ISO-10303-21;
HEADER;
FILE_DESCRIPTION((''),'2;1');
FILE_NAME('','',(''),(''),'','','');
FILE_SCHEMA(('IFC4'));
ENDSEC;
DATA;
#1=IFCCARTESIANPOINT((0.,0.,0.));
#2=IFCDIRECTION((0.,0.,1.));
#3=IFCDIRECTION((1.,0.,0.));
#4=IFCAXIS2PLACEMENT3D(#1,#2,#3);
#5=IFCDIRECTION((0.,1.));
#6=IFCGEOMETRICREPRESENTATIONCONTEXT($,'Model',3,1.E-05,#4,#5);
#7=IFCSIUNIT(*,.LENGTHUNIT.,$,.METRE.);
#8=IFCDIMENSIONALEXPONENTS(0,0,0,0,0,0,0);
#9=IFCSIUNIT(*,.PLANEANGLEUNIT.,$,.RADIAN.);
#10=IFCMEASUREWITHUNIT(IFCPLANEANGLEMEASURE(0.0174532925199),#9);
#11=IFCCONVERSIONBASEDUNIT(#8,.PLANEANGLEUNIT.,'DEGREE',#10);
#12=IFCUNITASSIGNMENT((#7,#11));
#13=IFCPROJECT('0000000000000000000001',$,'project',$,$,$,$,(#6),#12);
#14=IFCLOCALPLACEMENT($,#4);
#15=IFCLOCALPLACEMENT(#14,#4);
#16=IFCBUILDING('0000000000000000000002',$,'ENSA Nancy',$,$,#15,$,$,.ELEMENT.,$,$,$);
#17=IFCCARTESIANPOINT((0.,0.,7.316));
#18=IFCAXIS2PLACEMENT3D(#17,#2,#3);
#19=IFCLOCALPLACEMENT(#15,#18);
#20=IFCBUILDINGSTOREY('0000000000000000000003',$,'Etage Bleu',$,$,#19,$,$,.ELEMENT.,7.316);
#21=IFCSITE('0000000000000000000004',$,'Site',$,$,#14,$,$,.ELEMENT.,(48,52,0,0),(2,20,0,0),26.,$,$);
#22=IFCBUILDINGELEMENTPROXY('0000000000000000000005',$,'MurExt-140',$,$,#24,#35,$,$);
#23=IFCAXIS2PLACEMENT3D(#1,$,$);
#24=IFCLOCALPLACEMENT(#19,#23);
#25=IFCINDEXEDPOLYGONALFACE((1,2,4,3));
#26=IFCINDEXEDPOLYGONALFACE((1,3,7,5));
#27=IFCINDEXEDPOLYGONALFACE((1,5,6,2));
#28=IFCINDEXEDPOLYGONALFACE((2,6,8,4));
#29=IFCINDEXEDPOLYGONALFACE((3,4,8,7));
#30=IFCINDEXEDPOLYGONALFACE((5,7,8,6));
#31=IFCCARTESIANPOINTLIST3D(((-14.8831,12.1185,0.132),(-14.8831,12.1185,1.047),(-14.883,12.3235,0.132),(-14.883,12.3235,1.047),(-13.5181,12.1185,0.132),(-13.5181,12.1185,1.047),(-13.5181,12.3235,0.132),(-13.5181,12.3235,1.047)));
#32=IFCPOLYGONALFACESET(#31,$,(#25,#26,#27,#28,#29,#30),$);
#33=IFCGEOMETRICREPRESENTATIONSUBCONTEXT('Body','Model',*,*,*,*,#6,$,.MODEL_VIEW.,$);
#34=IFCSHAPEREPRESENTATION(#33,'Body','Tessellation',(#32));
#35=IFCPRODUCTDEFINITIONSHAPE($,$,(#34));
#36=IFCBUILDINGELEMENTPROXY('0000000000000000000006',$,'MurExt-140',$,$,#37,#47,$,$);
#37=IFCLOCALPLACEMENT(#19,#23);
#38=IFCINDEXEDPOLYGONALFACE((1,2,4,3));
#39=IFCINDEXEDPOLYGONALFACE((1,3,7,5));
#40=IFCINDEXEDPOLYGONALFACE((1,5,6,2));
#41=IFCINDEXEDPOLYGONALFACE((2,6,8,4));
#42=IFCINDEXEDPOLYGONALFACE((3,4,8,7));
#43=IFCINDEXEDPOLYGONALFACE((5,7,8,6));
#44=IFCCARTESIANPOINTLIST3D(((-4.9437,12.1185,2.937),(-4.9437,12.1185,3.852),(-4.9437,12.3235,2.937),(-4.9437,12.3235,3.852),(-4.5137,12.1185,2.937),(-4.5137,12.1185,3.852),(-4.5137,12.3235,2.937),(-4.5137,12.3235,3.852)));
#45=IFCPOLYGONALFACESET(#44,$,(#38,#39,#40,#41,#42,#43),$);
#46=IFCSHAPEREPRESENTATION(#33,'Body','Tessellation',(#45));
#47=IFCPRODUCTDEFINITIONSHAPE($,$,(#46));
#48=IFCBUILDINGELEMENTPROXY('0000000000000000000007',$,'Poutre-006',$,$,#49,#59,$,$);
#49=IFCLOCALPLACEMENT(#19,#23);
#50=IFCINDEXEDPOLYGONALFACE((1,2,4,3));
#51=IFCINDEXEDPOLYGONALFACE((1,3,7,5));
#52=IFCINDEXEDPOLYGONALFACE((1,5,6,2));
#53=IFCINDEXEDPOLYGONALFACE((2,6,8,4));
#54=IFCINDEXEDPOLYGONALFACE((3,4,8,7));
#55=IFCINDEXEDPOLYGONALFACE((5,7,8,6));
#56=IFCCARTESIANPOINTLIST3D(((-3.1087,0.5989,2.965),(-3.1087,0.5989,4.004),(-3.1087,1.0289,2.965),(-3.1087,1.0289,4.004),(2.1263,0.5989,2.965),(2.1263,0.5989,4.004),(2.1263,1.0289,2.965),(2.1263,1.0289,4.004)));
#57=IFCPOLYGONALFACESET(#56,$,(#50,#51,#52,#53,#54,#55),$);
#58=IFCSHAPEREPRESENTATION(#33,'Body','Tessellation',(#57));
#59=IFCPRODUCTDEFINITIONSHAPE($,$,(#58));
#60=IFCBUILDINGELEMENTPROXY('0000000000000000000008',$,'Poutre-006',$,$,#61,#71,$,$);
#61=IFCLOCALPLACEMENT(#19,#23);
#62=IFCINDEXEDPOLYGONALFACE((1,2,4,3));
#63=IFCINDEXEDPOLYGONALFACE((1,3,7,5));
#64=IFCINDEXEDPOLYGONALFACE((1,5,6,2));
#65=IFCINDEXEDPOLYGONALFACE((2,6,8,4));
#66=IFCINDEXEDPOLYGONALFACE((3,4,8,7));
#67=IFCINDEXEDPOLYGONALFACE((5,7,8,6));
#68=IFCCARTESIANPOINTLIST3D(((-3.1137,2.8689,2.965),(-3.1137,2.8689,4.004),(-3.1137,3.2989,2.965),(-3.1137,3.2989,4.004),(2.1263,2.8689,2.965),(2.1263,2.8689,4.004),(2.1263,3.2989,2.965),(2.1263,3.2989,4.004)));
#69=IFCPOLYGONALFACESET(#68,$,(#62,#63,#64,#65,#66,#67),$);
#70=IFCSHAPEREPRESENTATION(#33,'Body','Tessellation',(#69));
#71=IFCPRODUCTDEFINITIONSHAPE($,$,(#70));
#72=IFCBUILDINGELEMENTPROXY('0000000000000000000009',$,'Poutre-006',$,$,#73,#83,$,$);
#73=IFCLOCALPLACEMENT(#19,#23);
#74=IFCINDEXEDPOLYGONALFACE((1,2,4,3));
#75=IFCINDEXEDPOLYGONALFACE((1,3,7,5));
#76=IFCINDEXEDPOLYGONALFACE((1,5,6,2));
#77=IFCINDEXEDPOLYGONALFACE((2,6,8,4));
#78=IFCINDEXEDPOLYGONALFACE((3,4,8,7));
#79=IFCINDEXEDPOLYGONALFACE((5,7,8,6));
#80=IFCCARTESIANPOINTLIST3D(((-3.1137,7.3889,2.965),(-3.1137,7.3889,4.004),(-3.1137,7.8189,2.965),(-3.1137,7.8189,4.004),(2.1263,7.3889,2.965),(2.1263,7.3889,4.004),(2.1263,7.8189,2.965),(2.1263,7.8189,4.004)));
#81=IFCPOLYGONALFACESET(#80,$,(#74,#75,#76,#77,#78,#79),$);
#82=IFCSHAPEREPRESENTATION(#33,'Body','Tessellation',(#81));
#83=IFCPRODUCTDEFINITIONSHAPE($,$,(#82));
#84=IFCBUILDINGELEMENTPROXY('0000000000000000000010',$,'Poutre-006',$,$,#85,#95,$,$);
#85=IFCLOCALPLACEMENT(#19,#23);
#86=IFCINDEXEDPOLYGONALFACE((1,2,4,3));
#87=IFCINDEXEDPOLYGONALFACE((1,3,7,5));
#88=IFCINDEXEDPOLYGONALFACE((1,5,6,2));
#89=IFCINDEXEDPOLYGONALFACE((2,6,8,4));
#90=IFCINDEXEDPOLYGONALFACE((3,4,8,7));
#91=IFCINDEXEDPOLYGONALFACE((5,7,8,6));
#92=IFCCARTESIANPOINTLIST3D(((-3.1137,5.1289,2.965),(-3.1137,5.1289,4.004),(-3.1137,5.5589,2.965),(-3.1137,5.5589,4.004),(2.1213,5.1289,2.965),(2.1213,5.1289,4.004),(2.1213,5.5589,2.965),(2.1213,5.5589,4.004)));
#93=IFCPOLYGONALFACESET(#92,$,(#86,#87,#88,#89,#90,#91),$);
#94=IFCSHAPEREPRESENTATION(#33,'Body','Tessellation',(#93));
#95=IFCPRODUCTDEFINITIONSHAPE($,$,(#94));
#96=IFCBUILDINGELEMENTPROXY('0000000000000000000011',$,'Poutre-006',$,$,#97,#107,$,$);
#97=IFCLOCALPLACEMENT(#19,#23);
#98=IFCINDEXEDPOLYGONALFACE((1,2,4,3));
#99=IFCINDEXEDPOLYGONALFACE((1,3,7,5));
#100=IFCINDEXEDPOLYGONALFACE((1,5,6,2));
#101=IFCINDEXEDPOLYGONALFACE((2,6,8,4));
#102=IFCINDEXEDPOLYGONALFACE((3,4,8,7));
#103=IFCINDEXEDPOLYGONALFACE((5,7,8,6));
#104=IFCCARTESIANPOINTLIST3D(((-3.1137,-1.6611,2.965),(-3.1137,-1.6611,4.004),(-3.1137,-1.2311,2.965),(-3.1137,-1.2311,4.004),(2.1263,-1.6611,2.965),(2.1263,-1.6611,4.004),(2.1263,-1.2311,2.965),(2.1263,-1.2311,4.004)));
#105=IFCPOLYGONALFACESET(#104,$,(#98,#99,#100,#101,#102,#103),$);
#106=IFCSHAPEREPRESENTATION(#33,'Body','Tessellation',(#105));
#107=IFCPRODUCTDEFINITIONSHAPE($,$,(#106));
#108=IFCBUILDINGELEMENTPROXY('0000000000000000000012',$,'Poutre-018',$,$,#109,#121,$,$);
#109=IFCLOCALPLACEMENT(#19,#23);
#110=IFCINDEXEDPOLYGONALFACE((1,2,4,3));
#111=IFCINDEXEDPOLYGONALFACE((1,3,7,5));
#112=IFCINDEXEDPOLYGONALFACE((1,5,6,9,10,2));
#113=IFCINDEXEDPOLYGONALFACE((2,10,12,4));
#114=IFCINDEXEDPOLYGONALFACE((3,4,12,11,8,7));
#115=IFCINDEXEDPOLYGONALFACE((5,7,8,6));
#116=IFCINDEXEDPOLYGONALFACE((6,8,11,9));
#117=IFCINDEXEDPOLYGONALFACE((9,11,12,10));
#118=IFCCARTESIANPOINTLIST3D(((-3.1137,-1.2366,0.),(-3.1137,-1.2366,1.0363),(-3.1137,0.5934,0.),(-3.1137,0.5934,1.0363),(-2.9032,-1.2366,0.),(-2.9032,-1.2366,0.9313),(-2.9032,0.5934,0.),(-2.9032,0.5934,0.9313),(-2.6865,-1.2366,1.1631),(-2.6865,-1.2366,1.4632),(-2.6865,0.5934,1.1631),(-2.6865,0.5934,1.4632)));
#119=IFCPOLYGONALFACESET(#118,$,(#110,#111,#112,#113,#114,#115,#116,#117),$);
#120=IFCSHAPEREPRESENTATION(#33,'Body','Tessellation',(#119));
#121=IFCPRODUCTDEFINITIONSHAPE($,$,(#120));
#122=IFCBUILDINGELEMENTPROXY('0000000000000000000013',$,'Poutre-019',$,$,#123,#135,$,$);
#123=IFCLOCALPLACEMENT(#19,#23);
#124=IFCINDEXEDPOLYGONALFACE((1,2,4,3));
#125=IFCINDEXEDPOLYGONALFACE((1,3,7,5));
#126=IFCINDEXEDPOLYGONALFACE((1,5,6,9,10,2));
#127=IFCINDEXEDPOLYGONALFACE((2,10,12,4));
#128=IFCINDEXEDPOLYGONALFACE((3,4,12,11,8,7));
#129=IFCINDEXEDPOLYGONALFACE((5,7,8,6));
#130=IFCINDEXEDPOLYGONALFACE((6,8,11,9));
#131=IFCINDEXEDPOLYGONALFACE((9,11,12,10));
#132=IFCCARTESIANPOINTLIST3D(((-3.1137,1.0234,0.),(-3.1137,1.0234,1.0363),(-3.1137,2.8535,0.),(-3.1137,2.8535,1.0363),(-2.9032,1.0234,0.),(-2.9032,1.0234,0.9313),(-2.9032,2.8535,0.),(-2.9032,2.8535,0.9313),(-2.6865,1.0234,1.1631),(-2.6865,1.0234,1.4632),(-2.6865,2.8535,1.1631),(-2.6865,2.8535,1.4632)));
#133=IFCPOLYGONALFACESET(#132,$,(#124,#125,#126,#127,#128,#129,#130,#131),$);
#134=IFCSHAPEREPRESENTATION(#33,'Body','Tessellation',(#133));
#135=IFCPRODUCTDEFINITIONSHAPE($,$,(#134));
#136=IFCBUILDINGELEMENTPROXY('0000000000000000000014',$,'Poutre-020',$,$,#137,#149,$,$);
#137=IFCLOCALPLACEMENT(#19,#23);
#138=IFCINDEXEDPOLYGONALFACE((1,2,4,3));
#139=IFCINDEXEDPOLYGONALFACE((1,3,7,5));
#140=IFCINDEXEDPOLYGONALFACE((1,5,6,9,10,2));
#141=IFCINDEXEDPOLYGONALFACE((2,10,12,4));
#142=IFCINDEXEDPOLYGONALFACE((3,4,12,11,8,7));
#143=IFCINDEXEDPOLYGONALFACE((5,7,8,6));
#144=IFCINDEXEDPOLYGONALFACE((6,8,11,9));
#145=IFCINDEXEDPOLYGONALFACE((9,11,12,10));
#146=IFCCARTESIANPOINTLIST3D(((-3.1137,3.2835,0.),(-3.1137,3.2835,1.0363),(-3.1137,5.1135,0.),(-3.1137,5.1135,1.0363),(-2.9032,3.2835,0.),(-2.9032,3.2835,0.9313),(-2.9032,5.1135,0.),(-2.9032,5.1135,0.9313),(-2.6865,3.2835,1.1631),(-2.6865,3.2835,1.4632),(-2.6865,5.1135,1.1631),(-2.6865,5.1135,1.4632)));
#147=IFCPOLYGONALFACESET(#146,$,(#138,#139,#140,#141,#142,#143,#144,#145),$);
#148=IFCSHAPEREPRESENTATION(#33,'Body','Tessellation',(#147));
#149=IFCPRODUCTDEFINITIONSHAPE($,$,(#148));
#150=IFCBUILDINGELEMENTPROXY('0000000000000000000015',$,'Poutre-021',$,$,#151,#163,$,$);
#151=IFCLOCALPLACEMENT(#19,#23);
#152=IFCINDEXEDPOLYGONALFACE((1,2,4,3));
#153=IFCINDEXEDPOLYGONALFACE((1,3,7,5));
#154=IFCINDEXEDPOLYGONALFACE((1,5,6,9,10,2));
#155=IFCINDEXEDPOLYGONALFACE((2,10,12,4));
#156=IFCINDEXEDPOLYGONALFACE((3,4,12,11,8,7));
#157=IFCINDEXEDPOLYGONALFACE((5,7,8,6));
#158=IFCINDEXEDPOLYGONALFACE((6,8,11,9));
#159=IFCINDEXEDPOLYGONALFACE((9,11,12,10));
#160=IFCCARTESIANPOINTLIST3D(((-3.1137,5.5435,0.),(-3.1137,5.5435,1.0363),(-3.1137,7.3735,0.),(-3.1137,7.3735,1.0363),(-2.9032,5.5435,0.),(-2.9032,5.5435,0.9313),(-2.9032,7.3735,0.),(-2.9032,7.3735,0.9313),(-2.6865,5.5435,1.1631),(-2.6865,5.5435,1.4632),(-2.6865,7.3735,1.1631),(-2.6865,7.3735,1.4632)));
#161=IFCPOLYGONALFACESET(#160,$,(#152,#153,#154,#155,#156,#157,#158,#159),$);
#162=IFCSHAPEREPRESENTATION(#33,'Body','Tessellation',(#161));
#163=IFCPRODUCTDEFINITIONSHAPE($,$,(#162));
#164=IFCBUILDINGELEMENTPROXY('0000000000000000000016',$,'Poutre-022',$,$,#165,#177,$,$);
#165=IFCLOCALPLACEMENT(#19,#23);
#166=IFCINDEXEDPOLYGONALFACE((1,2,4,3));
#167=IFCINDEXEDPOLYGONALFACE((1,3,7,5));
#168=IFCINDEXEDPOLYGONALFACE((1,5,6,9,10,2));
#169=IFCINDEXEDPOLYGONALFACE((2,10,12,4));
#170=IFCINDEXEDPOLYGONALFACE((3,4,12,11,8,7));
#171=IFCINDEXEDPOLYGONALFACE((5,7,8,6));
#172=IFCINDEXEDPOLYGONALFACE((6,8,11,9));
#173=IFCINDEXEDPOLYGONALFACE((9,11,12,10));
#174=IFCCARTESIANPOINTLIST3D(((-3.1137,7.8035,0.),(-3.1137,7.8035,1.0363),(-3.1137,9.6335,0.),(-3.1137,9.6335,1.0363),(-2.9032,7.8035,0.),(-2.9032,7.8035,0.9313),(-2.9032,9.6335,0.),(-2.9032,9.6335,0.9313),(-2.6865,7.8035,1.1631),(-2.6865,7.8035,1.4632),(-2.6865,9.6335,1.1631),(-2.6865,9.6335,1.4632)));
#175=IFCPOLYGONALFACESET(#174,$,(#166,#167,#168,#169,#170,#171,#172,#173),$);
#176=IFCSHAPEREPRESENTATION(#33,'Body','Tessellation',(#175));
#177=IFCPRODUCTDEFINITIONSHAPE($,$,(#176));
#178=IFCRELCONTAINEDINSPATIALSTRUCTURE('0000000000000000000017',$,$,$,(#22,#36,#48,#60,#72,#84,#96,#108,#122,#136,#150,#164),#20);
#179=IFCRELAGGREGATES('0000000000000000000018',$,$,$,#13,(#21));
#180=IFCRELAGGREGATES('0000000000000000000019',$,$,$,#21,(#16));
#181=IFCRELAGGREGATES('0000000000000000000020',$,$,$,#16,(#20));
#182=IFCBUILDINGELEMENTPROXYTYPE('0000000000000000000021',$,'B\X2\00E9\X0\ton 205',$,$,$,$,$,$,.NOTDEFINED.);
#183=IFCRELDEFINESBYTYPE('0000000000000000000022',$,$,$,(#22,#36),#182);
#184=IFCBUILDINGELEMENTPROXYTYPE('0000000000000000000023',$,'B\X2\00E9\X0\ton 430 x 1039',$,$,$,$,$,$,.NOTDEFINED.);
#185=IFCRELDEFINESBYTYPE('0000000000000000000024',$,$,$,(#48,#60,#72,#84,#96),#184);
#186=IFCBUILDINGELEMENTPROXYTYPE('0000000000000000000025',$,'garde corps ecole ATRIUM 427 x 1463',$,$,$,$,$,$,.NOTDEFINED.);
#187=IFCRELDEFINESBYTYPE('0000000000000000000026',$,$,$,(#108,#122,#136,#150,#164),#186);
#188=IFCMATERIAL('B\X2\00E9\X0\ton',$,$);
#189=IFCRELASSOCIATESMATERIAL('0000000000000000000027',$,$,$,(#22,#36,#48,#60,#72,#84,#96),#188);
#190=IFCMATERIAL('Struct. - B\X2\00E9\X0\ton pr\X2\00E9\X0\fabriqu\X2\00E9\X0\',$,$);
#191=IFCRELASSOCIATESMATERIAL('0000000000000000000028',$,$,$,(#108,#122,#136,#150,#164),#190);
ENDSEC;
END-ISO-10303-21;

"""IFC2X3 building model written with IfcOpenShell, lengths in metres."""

from ifc_helpers import new_model, entity, si_unit, converted_unit, direction, frame, frame_2d, origin_with_axes, place, context, subcontext, project, spatial, polyline, rectangle, outline, extrude, material, type_object, element, save


model = new_model("IFC2X3")

# Units and contexts
model_context = context("Model", 3, precision=1e-05, world=origin_with_axes(), true_north=direction((0.0, 1.0)))
body_context = subcontext(model_context, "Body", "Model", "MODEL_VIEW")
ifc_project = project(units=[si_unit("LENGTHUNIT", "METRE"), converted_unit("PLANEANGLEUNIT", "DEGREE", entity("IfcPlaneAngleMeasure", 0.0174532925199), si_unit("PLANEANGLEUNIT", "RADIAN"), dimensions=[0, 0, 0, 0, 0, 0, 0])], contexts=[model_context])

# Site, building, storey
site_placement = place(None, origin_with_axes())
site = spatial("IfcSite", under=ifc_project, at=site_placement, Name="Site", CompositionType="ELEMENT", RefLatitude=(48, 52, 0, 0), RefLongitude=(2, 20, 0, 0), RefElevation=26.0)
building_placement = place(site_placement, origin_with_axes())
building = spatial("IfcBuilding", under=site, at=building_placement, Name="ENSA Nancy", CompositionType="ELEMENT")
storey_placement = place(building_placement, frame((0.0, 0.0, 7.316), z_axis=(0.0, 0.0, 1.0), x_axis=(1.0, 0.0, 0.0)))
storey = spatial("IfcBuildingStorey", under=building, at=storey_placement, Name="Etage Bleu", CompositionType="ELEMENT", Elevation=7.316)

# Building element proxies
ifc_material_1 = material(Name="Béton")
building_element_proxy_type_1 = type_object("IfcBuildingElementProxyType", Name="Béton 205", PredefinedType="NOTDEFINED")
for number, where, z_axis, x_axis, name in (
    (1, (-14.883, 12.3235, 0.132), (0.0, 0.0, 1.0), (1.0, -0.000005, 0.0), "MurExt-140"),
):
    element("IfcBuildingElementProxy", number, at=place(storey_placement, frame(where, z_axis=z_axis, x_axis=x_axis)), inside=storey, type_object=building_element_proxy_type_1, material=ifc_material_1, Name=name, context=body_context, shape_type="SweptSolid", body=[
        extrude(outline(polyline([(0.0, -0.205), (1.3649, -0.205), (1.3649, 0.0), (0.0, 0.0), (0.0, -0.205)])), origin_with_axes(), (0.0, 0.0, 1.0), 0.915),
    ])
proxy_1_placement = place(storey_placement, frame((-4.9437, 12.3235, 2.937), z_axis=(0.0, 0.0, 1.0), x_axis=(1.0, 0.0, 0.0)))
element("IfcBuildingElementProxy", 2, at=proxy_1_placement, inside=storey, type_object=building_element_proxy_type_1, material=ifc_material_1, Name="MurExt-140", context=body_context, shape_type="SweptSolid", body=[
    extrude(outline(polyline([(0.0, -0.205), (0.43, -0.205), (0.43, 0.0), (0.0, 0.0), (0.0, -0.205)])), origin_with_axes(), (0.0, 0.0, 1.0), 0.915),
])
building_element_proxy_type_2 = type_object("IfcBuildingElementProxyType", Name="Béton 430 x 1039", PredefinedType="NOTDEFINED")
proxy_2_placement = place(storey_placement, frame((-3.1087, 0.8139, 4.004), z_axis=(0.0, 0.0, 1.0), x_axis=(0.0, -1.0, 0.0)))
element("IfcBuildingElementProxy", 3, at=proxy_2_placement, inside=storey, type_object=building_element_proxy_type_2, material=ifc_material_1, Name="Poutre-006", context=body_context, shape_type="SweptSolid", body=[
    extrude(rectangle(XDim=1.039, YDim=0.43, at=frame_2d((-0.5195, 0.0), x_axis=(1.0, 0.0))), frame((0.0, 0.0, 0.0), z_axis=(0.0, 1.0, 0.0), x_axis=(0.0, 0.0, 1.0)), (0.0, 0.0, 1.0), 5.235),
])
for number, where, z_axis, x_axis, name in (
    (4, (-3.1137, 3.0839, 4.004), (0.0, 0.0, 1.0), (0.0, -1.0, 0.0), "Poutre-006"),
    (5, (-3.1137, 7.6039, 4.004), (0.0, 0.0, 1.0), (0.0, -1.0, 0.0), "Poutre-006"),
):
    element("IfcBuildingElementProxy", number, at=place(storey_placement, frame(where, z_axis=z_axis, x_axis=x_axis)), inside=storey, type_object=building_element_proxy_type_2, material=ifc_material_1, Name=name, context=body_context, shape_type="SweptSolid", body=[
        extrude(rectangle(XDim=1.039, YDim=0.43, at=frame_2d((-0.5195, 0.0), x_axis=(1.0, 0.0))), frame((0.0, 0.0, 0.0), z_axis=(0.0, 1.0, 0.0), x_axis=(0.0, 0.0, 1.0)), (0.0, 0.0, 1.0), 5.24),
    ])
proxy_3_placement = place(storey_placement, frame((-3.1137, 5.3439, 4.004), z_axis=(0.0, 0.0, 1.0), x_axis=(0.0, -1.0, 0.0)))
element("IfcBuildingElementProxy", 6, at=proxy_3_placement, inside=storey, type_object=building_element_proxy_type_2, material=ifc_material_1, Name="Poutre-006", context=body_context, shape_type="SweptSolid", body=[
    extrude(rectangle(XDim=1.039, YDim=0.43, at=frame_2d((-0.5195, 0.0), x_axis=(1.0, 0.0))), frame((0.0, 0.0, 0.0), z_axis=(0.0, 1.0, 0.0), x_axis=(0.0, 0.0, 1.0)), (0.0, 0.0, 1.0), 5.235),
])
proxy_4_placement = place(storey_placement, frame((-3.1137, -1.4461, 4.004), z_axis=(0.0, 0.0, 1.0), x_axis=(0.0, -1.0, 0.0)))
element("IfcBuildingElementProxy", 7, at=proxy_4_placement, inside=storey, type_object=building_element_proxy_type_2, material=ifc_material_1, Name="Poutre-006", context=body_context, shape_type="SweptSolid", body=[
    extrude(rectangle(XDim=1.039, YDim=0.43, at=frame_2d((-0.5195, 0.0), x_axis=(1.0, 0.0))), frame((0.0, 0.0, 0.0), z_axis=(0.0, 1.0, 0.0), x_axis=(0.0, 0.0, 1.0)), (0.0, 0.0, 1.0), 5.24),
])
ifc_material_2 = material(Name="Struct. - Béton préfabriqué")
building_element_proxy_type_3 = type_object("IfcBuildingElementProxyType", Name="garde corps ecole ATRIUM 427 x 1463", PredefinedType="NOTDEFINED")
proxy_5_placement = place(storey_placement, frame((-3.1137, -1.2366, 0.0), z_axis=(0.0, 0.0, 1.0), x_axis=(1.0, 0.0, 0.0)))
element("IfcBuildingElementProxy", 8, at=proxy_5_placement, inside=storey, type_object=building_element_proxy_type_3, material=ifc_material_2, Name="Poutre-018", context=body_context, shape_type="SweptSolid", body=[
    extrude(outline(polyline([(0.0, 1.0363), (0.0, 0.0), (0.2105, 0.0), (0.2105, 0.9313), (0.4272, 1.1631), (0.4272, 1.4632), (0.0, 1.0363)])), frame((0.0, 1.83, 0.0), z_axis=(0.0, -1.0, 0.0), x_axis=(1.0, 0.0, 0.0)), (0.0, 0.0, 1.0), 1.83),
])
proxy_6_placement = place(storey_placement, frame((-3.1137, 1.0234, 0.0), z_axis=(0.0, 0.0, 1.0), x_axis=(1.0, 0.0, 0.0)))
element("IfcBuildingElementProxy", 9, at=proxy_6_placement, inside=storey, type_object=building_element_proxy_type_3, material=ifc_material_2, Name="Poutre-019", context=body_context, shape_type="SweptSolid", body=[
    extrude(outline(polyline([(0.0, 1.0363), (0.0, 0.0), (0.2105, 0.0), (0.2105, 0.9313), (0.4272, 1.1631), (0.4272, 1.4632), (0.0, 1.0363)])), frame((0.0, 1.83, 0.0), z_axis=(0.0, -1.0, 0.0), x_axis=(1.0, 0.0, 0.0)), (0.0, 0.0, 1.0), 1.83),
])
proxy_7_placement = place(storey_placement, frame((-3.1137, 3.2835, 0.0), z_axis=(0.0, 0.0, 1.0), x_axis=(1.0, 0.0, 0.0)))
element("IfcBuildingElementProxy", 10, at=proxy_7_placement, inside=storey, type_object=building_element_proxy_type_3, material=ifc_material_2, Name="Poutre-020", context=body_context, shape_type="SweptSolid", body=[
    extrude(outline(polyline([(0.0, 1.0363), (0.0, 0.0), (0.2105, 0.0), (0.2105, 0.9313), (0.4272, 1.1631), (0.4272, 1.4632), (0.0, 1.0363)])), frame((0.0, 1.83, 0.0), z_axis=(0.0, -1.0, 0.0), x_axis=(1.0, 0.0, 0.0)), (0.0, 0.0, 1.0), 1.83),
])
proxy_8_placement = place(storey_placement, frame((-3.1137, 5.5435, 0.0), z_axis=(0.0, 0.0, 1.0), x_axis=(1.0, 0.0, 0.0)))
element("IfcBuildingElementProxy", 11, at=proxy_8_placement, inside=storey, type_object=building_element_proxy_type_3, material=ifc_material_2, Name="Poutre-021", context=body_context, shape_type="SweptSolid", body=[
    extrude(outline(polyline([(0.0, 1.0363), (0.0, 0.0), (0.2105, 0.0), (0.2105, 0.9313), (0.4272, 1.1631), (0.4272, 1.4632), (0.0, 1.0363)])), frame((0.0, 1.83, 0.0), z_axis=(0.0, -1.0, 0.0), x_axis=(1.0, 0.0, 0.0)), (0.0, 0.0, 1.0), 1.83),
])
proxy_9_placement = place(storey_placement, frame((-3.1137, 7.8035, 0.0), z_axis=(0.0, 0.0, 1.0), x_axis=(1.0, 0.0, 0.0)))
element("IfcBuildingElementProxy", 12, at=proxy_9_placement, inside=storey, type_object=building_element_proxy_type_3, material=ifc_material_2, Name="Poutre-022", context=body_context, shape_type="SweptSolid", body=[
    extrude(outline(polyline([(0.0, 1.0363), (0.0, 0.0), (0.2105, 0.0), (0.2105, 0.9313), (0.4272, 1.1631), (0.4272, 1.4632), (0.0, 1.0363)])), frame((0.0, 1.83, 0.0), z_axis=(0.0, -1.0, 0.0), x_axis=(1.0, 0.0, 0.0)), (0.0, 0.0, 1.0), 1.83),
])

save(model, "model.ifc")
